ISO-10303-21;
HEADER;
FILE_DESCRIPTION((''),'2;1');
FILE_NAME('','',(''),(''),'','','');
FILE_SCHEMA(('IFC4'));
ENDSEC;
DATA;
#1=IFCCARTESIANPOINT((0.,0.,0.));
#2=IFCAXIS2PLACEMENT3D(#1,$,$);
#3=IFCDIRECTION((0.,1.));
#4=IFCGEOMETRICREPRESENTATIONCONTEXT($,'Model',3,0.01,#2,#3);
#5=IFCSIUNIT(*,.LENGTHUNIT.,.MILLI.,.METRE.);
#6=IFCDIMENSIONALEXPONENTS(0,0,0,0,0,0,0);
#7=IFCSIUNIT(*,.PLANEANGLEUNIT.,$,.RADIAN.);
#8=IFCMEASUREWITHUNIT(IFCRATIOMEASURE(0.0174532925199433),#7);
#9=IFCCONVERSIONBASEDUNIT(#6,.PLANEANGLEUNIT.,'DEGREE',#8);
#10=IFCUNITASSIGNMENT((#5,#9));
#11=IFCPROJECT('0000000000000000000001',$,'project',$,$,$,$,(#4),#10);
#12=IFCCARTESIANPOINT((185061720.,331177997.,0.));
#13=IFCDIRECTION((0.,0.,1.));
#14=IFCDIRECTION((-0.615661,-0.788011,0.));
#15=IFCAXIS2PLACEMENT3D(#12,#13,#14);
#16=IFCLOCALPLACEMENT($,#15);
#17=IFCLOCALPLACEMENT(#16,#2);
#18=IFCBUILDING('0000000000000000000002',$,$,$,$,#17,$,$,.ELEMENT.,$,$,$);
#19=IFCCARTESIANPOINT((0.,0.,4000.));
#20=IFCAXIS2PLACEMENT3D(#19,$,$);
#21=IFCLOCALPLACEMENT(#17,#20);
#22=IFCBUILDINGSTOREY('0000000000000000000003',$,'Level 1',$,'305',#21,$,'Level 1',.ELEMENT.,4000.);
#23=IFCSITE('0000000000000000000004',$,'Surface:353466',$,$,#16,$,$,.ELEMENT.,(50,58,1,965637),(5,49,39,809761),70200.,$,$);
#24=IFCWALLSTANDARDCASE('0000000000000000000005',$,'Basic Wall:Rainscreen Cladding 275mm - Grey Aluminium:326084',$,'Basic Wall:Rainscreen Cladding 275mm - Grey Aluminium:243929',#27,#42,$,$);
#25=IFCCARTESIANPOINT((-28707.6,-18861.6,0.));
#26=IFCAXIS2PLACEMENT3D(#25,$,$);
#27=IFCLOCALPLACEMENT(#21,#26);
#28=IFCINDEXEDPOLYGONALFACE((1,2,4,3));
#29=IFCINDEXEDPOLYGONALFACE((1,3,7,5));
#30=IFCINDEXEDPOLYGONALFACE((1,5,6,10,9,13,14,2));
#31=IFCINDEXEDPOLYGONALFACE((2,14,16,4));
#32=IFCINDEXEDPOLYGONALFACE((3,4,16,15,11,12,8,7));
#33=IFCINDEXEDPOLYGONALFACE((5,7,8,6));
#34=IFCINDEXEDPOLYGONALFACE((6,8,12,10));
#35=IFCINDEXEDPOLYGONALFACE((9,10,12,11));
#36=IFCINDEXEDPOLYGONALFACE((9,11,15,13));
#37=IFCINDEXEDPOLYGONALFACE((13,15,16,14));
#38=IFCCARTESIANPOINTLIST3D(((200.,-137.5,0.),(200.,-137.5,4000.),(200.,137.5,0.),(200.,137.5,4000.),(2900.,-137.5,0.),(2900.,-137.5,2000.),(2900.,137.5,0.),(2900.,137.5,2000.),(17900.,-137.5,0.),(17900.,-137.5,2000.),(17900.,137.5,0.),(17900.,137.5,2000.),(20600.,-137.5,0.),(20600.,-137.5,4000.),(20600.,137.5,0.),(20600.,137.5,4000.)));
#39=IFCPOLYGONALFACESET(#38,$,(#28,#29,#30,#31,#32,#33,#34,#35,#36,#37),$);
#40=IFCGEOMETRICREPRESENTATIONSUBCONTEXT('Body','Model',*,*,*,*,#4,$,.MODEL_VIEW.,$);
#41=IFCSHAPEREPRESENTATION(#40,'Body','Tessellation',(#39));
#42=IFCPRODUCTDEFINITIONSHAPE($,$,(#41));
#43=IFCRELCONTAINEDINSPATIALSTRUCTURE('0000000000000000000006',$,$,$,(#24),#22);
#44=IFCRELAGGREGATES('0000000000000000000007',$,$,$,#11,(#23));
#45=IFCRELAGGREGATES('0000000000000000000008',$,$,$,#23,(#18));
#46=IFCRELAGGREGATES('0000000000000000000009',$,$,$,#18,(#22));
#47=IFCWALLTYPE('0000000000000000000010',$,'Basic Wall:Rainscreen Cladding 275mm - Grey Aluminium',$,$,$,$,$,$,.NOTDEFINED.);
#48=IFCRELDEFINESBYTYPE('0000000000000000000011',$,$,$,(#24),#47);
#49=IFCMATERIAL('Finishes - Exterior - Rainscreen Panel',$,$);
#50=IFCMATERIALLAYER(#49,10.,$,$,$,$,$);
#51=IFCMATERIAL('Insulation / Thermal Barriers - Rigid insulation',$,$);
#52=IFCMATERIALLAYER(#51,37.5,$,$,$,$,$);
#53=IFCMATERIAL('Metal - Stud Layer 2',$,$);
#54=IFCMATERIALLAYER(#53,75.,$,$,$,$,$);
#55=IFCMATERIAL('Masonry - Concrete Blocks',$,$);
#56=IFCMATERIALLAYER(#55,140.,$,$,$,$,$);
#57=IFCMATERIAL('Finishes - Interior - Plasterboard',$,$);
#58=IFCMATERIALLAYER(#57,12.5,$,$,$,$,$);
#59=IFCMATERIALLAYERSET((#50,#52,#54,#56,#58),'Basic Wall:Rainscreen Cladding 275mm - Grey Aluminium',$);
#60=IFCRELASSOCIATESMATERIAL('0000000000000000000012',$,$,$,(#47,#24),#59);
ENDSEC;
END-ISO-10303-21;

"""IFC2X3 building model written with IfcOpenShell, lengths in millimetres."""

from ifc_helpers import new_model, entity, si_unit, converted_unit, direction, frame, frame_2d, origin, place, context, subcontext, project, spatial, rectangle, extrude, clip, halfspace, material, layer, layer_set, layer_usage, type_object, element, save


model = new_model("IFC2X3")

# Units and contexts
model_context = context("Model", 3, precision=0.01, world=origin(), true_north=direction((0.0, 1.0)))
body_context = subcontext(model_context, "Body", "Model", "MODEL_VIEW")
ifc_project = project(units=[si_unit("LENGTHUNIT", "METRE", prefix="MILLI"), converted_unit("PLANEANGLEUNIT", "DEGREE", entity("IfcRatioMeasure", 0.0174532925199433), si_unit("PLANEANGLEUNIT", "RADIAN"), dimensions=[0, 0, 0, 0, 0, 0, 0])], contexts=[model_context])

# Site, building, storey
site_placement = place(None, frame((185061720.0, 331177997.0, 0.0), z_axis=(0.0, 0.0, 1.0), x_axis=(-0.615661, -0.788011, 0.0)))
site = spatial("IfcSite", under=ifc_project, at=site_placement, Name="Surface:353466", CompositionType="ELEMENT", RefLatitude=(50, 58, 1, 965637), RefLongitude=(5, 49, 39, 809761), RefElevation=70200.0)
building_placement = place(site_placement, origin())
building = spatial("IfcBuilding", under=site, at=building_placement, CompositionType="ELEMENT")
storey_placement = place(building_placement, frame((0.0, 0.0, 4000.0)))
storey = spatial("IfcBuildingStorey", under=building, at=storey_placement, Name="Level 1", ObjectType="305", LongName="Level 1", CompositionType="ELEMENT", Elevation=4000.0)

# Wall, opening
ifc_material_1 = material(Name="Finishes - Exterior - Rainscreen Panel")
ifc_layer_1 = layer(ifc_material_1, 10.0)
ifc_material_2 = material(Name="Insulation / Thermal Barriers - Rigid insulation")
ifc_layer_2 = layer(ifc_material_2, 37.5)
ifc_material_3 = material(Name="Metal - Stud Layer 2")
ifc_layer_3 = layer(ifc_material_3, 75.0)
ifc_material_4 = material(Name="Masonry - Concrete Blocks")
ifc_layer_4 = layer(ifc_material_4, 140.0)
ifc_material_5 = material(Name="Finishes - Interior - Plasterboard")
ifc_layer_5 = layer(ifc_material_5, 12.5)
ifc_layer_set_1 = layer_set([ifc_layer_1, ifc_layer_2, ifc_layer_3, ifc_layer_4, ifc_layer_5], Name="Basic Wall:Rainscreen Cladding 275mm - Grey Aluminium")
ifc_layer_usage_1 = layer_usage(ifc_layer_set_1, "AXIS2", "POSITIVE", -137.5)
wall_type_1 = type_object("IfcWallType", Name="Basic Wall:Rainscreen Cladding 275mm - Grey Aluminium", PredefinedType="NOTDEFINED", material=ifc_layer_set_1)
wall_1_placement = place(storey_placement, frame((-28707.6, -18861.6, 0.0)))
wall_1 = element("IfcWallStandardCase", 1, at=wall_1_placement, inside=storey, type_object=wall_type_1, material=ifc_layer_usage_1, Name="Basic Wall:Rainscreen Cladding 275mm - Grey Aluminium:326084", ObjectType="Basic Wall:Rainscreen Cladding 275mm - Grey Aluminium:243929", context=body_context, shape_type="Clipping", body=[
    clip(extrude(rectangle(XDim=20400.0, YDim=275.0, at=frame_2d((10400.0, 0.0), x_axis=(1.0, 0.0))), origin(), (0.0, 0.0, 1.0), 4000.0), halfspace(frame((0.0, 0.0, -4000.0)), True)),
])
opening_1_placement = place(wall_1_placement, frame((2900.0, -289.9, 0.0)))
element("IfcOpeningElement", 2, at=opening_1_placement, cuts=wall_1, ObjectType="Opening", context=body_context, shape_type="SweptSolid", body=[
    extrude(rectangle(XDim=2000.0, YDim=15000.0, at=frame_2d((0.0, 0.0), x_axis=(1.0, 0.0))), frame((7500.0, 0.0, 1000.0), z_axis=(0.0, 1.0, 0.0), x_axis=(0.0, 0.0, 1.0)), (0.0, 0.0, 1.0), 579.8),
])

save(model, "model.ifc")
